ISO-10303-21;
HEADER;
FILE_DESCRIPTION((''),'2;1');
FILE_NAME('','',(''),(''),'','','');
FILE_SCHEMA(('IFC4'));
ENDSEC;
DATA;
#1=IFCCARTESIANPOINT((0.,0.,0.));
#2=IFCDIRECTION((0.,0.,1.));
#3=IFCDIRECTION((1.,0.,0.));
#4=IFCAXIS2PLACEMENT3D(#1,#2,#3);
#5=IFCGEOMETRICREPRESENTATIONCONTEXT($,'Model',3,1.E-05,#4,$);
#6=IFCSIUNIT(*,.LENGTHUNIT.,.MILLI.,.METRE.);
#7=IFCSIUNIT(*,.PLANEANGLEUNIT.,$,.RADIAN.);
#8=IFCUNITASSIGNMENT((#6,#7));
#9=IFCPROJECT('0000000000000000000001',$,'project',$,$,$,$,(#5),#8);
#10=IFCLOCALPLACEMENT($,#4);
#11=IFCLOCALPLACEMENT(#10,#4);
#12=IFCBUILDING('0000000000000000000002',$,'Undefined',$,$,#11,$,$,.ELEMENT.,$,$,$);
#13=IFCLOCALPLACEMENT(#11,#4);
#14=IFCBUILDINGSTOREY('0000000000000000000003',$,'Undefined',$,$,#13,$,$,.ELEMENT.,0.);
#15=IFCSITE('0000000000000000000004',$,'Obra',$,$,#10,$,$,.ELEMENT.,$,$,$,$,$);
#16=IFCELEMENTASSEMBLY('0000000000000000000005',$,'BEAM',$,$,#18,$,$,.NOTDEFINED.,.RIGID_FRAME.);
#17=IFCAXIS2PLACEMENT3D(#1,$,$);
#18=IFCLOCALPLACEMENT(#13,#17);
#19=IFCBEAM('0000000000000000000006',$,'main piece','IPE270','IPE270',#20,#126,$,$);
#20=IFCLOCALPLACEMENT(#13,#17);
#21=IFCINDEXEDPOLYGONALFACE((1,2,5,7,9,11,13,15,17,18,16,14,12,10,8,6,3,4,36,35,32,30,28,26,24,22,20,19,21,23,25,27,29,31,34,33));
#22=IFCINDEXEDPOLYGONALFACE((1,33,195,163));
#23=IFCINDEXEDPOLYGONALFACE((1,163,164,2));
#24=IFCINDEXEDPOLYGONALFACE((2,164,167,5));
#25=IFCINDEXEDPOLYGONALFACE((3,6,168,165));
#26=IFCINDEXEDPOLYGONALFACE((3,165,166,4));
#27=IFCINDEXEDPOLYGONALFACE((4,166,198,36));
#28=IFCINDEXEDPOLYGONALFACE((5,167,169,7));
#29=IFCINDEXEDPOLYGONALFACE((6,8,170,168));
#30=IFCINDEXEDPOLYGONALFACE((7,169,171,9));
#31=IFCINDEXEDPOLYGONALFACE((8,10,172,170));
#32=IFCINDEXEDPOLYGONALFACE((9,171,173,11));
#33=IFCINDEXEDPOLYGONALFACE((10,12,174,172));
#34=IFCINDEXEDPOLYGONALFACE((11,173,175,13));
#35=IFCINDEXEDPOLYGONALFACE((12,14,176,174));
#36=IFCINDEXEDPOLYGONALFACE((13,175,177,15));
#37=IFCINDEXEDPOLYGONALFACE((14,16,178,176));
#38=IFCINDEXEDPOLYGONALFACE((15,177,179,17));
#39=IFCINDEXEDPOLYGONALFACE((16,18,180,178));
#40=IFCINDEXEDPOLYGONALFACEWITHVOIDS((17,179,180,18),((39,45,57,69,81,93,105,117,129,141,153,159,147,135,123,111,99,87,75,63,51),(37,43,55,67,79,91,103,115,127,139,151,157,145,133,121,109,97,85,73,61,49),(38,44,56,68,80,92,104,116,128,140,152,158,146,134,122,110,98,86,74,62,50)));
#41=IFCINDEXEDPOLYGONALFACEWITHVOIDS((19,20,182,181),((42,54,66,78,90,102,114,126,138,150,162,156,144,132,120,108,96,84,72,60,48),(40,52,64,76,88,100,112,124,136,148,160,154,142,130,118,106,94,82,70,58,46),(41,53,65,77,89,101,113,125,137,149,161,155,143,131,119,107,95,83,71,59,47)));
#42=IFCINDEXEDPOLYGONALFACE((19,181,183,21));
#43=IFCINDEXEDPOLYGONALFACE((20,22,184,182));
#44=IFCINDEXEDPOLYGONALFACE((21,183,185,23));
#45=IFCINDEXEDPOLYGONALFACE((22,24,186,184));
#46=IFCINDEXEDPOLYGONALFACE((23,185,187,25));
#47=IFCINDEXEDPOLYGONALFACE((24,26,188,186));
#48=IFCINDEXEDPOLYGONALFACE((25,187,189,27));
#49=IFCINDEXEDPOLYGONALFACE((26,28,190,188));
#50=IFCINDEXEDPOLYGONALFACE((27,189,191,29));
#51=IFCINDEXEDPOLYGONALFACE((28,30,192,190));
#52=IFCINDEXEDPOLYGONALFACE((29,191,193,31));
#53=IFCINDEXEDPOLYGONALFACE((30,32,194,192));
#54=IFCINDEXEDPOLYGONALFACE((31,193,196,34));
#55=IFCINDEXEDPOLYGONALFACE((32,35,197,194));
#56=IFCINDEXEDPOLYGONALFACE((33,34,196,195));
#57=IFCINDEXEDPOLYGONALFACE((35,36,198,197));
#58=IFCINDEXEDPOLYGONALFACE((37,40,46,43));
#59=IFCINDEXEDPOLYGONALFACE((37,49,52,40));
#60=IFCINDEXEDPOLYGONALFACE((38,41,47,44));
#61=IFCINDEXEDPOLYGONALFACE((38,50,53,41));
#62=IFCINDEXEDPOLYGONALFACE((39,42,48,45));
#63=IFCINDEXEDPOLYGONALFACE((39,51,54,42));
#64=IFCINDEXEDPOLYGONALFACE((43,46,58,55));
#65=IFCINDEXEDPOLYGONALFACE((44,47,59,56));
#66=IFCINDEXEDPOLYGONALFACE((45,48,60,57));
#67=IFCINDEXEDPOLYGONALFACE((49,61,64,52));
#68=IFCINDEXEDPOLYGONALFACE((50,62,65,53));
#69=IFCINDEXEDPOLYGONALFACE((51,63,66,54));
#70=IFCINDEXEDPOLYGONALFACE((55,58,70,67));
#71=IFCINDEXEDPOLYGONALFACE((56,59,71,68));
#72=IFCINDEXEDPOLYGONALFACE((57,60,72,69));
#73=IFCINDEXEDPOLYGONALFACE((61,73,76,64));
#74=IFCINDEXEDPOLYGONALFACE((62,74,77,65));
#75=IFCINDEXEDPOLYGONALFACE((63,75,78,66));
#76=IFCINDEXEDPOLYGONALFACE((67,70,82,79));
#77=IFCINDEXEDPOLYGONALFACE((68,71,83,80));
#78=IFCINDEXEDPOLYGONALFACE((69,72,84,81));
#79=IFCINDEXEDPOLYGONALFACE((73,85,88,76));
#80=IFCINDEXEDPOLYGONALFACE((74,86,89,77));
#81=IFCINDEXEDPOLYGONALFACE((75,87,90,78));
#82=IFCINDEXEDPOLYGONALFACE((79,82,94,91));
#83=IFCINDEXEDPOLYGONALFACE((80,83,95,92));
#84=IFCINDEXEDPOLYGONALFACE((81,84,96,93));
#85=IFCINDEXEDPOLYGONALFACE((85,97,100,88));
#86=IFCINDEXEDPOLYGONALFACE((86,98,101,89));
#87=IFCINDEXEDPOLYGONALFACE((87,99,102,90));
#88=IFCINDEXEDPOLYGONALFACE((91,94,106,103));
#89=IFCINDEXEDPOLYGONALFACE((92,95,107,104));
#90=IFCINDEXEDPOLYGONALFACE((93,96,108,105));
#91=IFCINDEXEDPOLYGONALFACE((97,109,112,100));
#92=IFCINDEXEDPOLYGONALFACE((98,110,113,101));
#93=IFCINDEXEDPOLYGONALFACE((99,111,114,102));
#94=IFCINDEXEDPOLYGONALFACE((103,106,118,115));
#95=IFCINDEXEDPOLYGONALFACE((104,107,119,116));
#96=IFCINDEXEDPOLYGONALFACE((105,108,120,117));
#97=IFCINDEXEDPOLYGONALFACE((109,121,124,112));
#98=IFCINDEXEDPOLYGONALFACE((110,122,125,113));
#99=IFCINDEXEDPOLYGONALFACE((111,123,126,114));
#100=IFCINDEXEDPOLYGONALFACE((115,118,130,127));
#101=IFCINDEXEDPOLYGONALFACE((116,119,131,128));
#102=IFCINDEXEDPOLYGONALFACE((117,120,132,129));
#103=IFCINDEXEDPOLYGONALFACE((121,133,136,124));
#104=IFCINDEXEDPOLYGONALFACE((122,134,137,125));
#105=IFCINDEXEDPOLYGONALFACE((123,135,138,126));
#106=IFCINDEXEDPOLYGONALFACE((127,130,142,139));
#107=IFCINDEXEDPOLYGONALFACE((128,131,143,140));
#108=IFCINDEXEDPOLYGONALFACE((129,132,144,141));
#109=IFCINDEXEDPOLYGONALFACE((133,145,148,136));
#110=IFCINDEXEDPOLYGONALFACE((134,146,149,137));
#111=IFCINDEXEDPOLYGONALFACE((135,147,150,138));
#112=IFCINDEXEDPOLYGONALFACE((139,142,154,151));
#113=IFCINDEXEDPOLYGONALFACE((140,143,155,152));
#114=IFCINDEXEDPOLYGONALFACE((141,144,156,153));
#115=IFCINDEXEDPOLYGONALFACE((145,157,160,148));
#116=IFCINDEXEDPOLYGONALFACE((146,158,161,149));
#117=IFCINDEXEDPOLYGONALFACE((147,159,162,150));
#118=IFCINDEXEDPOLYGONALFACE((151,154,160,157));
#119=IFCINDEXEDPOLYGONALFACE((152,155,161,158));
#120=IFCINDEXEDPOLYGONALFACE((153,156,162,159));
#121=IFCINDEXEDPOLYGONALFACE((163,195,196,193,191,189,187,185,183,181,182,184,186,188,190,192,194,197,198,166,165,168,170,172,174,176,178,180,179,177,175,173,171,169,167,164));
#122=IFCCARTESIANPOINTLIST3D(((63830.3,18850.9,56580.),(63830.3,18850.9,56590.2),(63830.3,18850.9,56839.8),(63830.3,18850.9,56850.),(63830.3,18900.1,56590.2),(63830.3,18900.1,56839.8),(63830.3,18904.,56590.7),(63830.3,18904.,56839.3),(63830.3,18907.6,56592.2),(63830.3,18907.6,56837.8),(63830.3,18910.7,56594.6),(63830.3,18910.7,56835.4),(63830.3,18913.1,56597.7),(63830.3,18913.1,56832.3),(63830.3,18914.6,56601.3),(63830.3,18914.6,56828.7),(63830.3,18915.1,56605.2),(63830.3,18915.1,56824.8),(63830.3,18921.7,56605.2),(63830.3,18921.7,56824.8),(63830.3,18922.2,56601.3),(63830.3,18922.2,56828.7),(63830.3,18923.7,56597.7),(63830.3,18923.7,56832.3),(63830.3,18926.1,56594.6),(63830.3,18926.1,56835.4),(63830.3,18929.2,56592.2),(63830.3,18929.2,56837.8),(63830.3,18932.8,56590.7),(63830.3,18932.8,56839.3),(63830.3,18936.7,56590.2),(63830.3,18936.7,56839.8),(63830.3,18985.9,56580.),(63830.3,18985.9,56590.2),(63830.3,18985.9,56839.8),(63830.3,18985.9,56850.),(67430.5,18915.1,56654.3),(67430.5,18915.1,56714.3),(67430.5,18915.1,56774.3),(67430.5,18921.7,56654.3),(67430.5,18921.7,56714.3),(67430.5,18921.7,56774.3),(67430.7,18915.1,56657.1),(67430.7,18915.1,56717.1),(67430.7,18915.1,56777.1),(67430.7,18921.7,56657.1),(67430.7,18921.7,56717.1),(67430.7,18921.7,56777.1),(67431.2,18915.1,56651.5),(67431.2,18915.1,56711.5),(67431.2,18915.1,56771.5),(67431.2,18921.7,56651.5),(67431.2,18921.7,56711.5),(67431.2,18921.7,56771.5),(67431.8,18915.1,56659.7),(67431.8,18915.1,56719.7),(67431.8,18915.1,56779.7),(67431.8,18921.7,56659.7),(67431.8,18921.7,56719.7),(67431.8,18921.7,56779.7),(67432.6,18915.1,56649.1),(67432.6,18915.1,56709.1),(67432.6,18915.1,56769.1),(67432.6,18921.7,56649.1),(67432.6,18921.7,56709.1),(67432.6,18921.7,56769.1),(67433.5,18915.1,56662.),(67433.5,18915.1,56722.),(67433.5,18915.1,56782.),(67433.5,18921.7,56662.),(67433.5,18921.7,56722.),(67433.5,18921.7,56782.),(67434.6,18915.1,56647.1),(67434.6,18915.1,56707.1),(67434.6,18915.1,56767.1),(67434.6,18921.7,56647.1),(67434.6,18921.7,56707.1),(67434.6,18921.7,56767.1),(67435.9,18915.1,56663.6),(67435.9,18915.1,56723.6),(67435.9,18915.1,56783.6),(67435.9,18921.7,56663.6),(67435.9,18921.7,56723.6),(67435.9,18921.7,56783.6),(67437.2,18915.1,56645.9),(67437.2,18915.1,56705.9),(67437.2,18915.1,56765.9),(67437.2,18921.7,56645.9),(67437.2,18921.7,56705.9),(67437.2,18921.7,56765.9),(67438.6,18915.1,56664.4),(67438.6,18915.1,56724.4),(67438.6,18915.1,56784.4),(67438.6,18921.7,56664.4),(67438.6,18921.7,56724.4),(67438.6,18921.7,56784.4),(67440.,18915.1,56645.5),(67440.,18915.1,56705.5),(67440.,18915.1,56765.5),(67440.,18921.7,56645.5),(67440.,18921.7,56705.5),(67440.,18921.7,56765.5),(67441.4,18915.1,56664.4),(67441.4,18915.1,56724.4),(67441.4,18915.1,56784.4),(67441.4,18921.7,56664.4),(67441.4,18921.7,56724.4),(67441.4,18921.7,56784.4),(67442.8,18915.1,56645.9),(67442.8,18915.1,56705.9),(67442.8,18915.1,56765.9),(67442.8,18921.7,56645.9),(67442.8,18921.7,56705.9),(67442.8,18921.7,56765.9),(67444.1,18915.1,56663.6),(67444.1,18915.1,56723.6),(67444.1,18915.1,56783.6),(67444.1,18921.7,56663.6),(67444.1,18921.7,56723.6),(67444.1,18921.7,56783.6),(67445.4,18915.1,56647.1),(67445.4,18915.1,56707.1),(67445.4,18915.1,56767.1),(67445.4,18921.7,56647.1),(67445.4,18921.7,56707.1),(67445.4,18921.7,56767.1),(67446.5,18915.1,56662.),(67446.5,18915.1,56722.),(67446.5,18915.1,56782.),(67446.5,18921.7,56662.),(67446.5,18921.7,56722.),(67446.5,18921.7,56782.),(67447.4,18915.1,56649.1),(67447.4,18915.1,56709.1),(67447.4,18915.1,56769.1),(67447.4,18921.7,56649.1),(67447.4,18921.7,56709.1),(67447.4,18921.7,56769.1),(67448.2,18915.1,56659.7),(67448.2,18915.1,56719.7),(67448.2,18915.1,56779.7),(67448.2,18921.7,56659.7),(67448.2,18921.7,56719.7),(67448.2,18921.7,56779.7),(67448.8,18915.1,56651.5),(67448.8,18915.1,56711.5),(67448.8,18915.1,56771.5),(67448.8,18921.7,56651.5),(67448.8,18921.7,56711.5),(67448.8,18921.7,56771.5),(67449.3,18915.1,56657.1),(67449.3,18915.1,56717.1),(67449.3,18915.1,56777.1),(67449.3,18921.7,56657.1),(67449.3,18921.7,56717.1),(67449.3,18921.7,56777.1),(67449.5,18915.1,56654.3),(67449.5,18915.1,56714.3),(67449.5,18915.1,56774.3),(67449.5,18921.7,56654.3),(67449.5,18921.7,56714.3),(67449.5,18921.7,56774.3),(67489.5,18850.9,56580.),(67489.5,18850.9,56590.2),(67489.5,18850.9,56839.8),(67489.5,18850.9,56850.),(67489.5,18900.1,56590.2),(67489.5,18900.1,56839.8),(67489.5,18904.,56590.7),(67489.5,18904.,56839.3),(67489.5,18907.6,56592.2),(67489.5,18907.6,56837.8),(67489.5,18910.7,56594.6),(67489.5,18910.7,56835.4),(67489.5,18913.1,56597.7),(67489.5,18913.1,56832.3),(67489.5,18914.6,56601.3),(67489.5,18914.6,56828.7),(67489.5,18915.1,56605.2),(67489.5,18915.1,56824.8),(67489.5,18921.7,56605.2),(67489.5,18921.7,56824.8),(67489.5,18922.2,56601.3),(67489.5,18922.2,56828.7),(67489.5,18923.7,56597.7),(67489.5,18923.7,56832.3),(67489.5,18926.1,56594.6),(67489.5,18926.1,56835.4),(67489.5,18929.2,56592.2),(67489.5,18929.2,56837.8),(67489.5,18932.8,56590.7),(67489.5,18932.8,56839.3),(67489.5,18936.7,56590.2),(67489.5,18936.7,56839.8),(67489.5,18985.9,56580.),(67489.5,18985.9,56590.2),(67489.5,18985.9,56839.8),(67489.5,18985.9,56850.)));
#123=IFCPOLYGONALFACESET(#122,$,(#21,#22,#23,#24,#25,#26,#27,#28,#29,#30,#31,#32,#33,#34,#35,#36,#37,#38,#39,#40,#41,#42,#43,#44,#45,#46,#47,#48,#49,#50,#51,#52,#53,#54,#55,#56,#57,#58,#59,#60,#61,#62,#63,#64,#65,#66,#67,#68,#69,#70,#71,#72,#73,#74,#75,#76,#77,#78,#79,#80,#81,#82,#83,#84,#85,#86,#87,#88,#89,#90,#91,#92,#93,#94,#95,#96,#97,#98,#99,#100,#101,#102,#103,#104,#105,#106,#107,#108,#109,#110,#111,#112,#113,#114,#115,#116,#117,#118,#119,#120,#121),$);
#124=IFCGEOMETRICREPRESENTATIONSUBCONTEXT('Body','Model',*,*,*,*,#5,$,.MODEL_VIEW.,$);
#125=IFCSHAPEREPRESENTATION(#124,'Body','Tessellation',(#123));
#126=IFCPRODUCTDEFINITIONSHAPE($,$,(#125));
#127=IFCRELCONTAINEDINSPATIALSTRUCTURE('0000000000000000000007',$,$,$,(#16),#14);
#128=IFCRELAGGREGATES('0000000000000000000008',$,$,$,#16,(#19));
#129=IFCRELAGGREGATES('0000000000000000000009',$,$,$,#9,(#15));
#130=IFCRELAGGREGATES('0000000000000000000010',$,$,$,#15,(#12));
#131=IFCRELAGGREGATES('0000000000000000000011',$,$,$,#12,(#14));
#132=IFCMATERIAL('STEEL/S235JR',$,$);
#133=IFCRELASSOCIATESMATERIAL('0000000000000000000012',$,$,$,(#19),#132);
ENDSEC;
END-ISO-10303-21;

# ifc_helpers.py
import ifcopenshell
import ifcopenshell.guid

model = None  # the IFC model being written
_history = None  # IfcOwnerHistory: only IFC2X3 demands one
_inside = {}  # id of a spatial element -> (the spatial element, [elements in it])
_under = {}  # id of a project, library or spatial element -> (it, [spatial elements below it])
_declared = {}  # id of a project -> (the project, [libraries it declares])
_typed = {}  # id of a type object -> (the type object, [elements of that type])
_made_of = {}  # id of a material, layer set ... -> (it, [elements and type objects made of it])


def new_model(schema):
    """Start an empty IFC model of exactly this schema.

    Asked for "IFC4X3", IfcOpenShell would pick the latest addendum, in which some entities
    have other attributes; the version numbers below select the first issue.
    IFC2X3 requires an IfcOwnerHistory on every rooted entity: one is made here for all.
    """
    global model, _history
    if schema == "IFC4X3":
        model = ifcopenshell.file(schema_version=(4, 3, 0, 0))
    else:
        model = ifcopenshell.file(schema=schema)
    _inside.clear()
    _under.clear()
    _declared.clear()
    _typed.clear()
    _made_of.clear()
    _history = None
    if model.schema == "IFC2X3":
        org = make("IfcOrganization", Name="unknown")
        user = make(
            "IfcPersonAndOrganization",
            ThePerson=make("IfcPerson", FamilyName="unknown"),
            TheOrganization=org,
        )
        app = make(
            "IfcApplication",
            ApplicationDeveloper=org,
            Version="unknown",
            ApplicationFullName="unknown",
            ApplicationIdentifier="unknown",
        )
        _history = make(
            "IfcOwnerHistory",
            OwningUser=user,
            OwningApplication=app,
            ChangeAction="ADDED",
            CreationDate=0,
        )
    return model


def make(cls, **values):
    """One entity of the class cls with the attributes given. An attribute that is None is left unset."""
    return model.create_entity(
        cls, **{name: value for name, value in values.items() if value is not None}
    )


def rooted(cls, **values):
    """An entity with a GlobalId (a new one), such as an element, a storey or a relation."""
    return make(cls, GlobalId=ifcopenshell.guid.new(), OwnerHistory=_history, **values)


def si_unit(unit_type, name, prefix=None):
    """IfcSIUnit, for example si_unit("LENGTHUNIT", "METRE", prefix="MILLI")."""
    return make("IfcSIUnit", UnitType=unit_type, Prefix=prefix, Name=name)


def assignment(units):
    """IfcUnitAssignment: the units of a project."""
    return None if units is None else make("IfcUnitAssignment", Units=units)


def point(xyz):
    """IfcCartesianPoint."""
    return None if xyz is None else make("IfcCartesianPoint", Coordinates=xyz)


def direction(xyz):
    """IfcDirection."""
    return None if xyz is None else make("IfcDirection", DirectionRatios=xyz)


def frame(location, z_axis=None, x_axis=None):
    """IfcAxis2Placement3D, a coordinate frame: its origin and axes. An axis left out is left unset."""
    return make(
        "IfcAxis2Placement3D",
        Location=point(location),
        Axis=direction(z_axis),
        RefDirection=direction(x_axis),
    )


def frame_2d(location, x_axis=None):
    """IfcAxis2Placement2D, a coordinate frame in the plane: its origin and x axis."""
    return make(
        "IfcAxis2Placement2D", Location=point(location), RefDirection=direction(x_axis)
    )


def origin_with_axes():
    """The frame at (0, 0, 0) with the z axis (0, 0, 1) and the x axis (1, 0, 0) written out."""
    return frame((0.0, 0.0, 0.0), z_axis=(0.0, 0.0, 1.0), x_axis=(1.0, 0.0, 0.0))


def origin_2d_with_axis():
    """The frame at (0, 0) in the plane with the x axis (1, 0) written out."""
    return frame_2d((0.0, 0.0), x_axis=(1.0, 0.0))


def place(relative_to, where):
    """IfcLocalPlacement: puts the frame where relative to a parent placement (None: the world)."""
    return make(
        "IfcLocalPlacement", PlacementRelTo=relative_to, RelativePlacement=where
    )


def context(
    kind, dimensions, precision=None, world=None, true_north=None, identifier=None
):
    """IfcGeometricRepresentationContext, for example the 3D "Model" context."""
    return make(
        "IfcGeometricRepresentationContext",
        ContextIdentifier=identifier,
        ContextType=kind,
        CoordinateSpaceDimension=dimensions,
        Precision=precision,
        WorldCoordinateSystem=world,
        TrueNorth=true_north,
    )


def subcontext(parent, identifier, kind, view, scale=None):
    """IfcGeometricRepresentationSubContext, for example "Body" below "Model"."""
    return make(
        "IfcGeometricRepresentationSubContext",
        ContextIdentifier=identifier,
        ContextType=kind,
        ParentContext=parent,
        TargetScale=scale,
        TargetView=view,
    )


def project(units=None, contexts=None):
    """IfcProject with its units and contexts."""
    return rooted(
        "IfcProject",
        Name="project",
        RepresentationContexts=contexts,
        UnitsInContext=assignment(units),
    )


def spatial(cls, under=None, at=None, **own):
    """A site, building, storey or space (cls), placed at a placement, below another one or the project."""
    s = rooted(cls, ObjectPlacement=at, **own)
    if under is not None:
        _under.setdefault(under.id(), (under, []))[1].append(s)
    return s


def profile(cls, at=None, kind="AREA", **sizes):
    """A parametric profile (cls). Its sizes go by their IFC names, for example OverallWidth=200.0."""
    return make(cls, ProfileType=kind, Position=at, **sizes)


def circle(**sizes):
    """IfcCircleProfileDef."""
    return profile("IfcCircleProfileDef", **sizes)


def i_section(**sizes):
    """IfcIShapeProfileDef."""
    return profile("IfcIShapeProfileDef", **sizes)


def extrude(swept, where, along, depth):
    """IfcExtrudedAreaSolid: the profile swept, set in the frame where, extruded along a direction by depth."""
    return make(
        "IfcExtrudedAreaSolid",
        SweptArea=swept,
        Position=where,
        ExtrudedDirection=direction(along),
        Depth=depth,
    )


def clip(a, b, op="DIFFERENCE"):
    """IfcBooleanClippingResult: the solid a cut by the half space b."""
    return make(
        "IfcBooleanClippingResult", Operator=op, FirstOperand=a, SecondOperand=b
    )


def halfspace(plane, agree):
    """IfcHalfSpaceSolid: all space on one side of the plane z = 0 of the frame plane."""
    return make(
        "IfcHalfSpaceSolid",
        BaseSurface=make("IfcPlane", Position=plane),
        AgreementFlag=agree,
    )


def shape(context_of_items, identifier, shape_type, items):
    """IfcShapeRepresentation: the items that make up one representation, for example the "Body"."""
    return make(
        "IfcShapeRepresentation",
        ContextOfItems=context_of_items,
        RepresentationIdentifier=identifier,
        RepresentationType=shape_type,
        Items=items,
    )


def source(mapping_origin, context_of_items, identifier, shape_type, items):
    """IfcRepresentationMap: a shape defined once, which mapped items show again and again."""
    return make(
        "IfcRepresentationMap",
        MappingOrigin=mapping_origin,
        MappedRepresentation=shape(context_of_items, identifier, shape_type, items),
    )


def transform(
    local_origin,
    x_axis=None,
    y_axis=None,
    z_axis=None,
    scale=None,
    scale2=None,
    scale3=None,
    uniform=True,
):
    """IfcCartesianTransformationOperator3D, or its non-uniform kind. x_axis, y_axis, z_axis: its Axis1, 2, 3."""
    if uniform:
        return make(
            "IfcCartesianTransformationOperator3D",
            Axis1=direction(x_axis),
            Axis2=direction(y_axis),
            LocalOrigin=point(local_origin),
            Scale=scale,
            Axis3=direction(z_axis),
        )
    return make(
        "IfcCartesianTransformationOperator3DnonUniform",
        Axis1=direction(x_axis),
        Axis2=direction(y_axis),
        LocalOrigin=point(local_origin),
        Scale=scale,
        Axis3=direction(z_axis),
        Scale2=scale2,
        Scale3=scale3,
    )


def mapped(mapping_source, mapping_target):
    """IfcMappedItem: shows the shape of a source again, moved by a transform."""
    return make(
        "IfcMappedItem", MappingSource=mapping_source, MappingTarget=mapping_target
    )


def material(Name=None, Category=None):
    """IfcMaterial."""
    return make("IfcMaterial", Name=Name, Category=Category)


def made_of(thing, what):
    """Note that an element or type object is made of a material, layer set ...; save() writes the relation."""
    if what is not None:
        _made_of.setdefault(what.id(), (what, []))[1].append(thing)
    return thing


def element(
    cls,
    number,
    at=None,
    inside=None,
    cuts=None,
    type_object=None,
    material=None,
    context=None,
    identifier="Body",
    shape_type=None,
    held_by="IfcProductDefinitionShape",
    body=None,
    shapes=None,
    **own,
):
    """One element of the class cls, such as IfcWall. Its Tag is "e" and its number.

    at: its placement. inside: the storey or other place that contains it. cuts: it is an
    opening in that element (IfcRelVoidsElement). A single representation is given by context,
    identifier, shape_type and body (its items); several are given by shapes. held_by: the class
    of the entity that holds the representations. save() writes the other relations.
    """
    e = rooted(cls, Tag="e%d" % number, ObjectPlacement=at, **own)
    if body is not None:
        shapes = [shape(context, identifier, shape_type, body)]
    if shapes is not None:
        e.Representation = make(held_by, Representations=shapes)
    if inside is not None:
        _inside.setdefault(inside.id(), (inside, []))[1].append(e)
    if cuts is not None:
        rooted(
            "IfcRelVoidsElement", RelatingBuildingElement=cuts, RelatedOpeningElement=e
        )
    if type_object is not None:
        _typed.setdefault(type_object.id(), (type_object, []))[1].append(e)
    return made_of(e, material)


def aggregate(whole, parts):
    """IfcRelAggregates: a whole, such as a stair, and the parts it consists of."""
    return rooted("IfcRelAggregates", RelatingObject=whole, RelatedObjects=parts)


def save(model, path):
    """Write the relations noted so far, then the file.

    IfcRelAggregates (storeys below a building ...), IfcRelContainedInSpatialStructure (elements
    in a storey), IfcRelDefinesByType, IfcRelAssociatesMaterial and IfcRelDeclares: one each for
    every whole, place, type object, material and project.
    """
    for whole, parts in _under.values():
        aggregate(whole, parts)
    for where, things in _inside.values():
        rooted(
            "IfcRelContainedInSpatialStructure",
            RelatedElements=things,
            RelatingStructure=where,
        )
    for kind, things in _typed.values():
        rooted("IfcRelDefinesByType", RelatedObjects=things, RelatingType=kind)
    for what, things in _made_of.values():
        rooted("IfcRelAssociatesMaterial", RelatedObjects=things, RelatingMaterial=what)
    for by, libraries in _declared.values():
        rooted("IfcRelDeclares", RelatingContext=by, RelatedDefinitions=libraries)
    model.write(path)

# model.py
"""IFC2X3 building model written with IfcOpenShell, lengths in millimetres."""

from ifc_helpers import new_model, si_unit, frame, origin_with_axes, origin_2d_with_axis, place, context, subcontext, project, spatial, circle, i_section, extrude, clip, halfspace, source, transform, mapped, material, element, aggregate, save


model = new_model("IFC2X3")

# Units and contexts
model_context = context("Model", 3, precision=1e-05, world=origin_with_axes())
body_context = subcontext(model_context, "Body", "Model", "MODEL_VIEW")
ifc_project = project(units=[si_unit("LENGTHUNIT", "METRE", prefix="MILLI"), si_unit("PLANEANGLEUNIT", "RADIAN")], contexts=[model_context])

# Site, building, storey
site_placement = place(None, origin_with_axes())
site = spatial("IfcSite", under=ifc_project, at=site_placement, Name="Obra", CompositionType="ELEMENT")
building_placement = place(site_placement, origin_with_axes())
building = spatial("IfcBuilding", under=site, at=building_placement, Name="Undefined", CompositionType="ELEMENT")
storey_placement = place(building_placement, origin_with_axes())
storey = spatial("IfcBuildingStorey", under=building, at=storey_placement, Name="Undefined", CompositionType="ELEMENT", Elevation=0.0)

# Shared definitions
ifc_material_1 = material(Name="STEEL/S235JR")

# Element assembly, beam, opening
assembly_1_placement = place(storey_placement, origin_with_axes())
assembly_1 = element("IfcElementAssembly", 1, at=assembly_1_placement, inside=storey, Name="BEAM", AssemblyPlace="NOTDEFINED", PredefinedType="RIGID_FRAME")
beam_1_placement = place(assembly_1_placement, frame((63830.3, 18918.4, 56715.0), z_axis=(0.0, 0.0, 1.0), x_axis=(1.0, 0.000002, 0.0)))
beam_1 = element("IfcBeam", 2, at=beam_1_placement, material=ifc_material_1, Name="main piece", Description="IPE270", ObjectType="IPE270", context=body_context, shape_type="Clipping", body=[
    clip(extrude(i_section(OverallWidth=135.0, OverallDepth=270.0, WebThickness=6.6, FlangeThickness=10.2, FilletRadius=15.0, at=origin_2d_with_axis()), frame((3910.9, 0.0, 0.0), z_axis=(-1.0, 0.0, 0.0), x_axis=(0.0, -1.0, 0.0)), (0.0, 0.0, 1.0), 3910.9), halfspace(frame((3659.2, -60.0, -120.0), z_axis=(1.0, 0.000017, 0.0), x_axis=(0.0, 0.0, 1.0)), False)),
])
shared_shape_1 = source(origin_with_axes(), body_context, "Body", "SweptSolid", [
    extrude(circle(Radius=9.5, at=origin_2d_with_axis()), frame((0.0, -3.4, 0.0), z_axis=(0.0, 1.0, 0.0), x_axis=(1.0, 0.0, 0.0)), (0.0, 0.0, 1.0), 6.8),
])
opening_1_placement = place(assembly_1_placement, frame((67490.0, 18918.4, 56835.0), z_axis=(-1.0, 0.0, 0.0), x_axis=(0.0, 0.0, -1.0)))
element("IfcOpeningElement", 3, at=opening_1_placement, cuts=beam_1, ObjectType="Opening", context=body_context, shape_type="MappedRepresentation", body=[
    mapped(shared_shape_1, transform((60.0, 0.0, 50.0))),
    mapped(shared_shape_1, transform((120.0, 0.0, 50.0))),
    mapped(shared_shape_1, transform((180.0, 0.0, 50.0))),
])
aggregate(assembly_1, [beam_1])

save(model, "model.ifc")
